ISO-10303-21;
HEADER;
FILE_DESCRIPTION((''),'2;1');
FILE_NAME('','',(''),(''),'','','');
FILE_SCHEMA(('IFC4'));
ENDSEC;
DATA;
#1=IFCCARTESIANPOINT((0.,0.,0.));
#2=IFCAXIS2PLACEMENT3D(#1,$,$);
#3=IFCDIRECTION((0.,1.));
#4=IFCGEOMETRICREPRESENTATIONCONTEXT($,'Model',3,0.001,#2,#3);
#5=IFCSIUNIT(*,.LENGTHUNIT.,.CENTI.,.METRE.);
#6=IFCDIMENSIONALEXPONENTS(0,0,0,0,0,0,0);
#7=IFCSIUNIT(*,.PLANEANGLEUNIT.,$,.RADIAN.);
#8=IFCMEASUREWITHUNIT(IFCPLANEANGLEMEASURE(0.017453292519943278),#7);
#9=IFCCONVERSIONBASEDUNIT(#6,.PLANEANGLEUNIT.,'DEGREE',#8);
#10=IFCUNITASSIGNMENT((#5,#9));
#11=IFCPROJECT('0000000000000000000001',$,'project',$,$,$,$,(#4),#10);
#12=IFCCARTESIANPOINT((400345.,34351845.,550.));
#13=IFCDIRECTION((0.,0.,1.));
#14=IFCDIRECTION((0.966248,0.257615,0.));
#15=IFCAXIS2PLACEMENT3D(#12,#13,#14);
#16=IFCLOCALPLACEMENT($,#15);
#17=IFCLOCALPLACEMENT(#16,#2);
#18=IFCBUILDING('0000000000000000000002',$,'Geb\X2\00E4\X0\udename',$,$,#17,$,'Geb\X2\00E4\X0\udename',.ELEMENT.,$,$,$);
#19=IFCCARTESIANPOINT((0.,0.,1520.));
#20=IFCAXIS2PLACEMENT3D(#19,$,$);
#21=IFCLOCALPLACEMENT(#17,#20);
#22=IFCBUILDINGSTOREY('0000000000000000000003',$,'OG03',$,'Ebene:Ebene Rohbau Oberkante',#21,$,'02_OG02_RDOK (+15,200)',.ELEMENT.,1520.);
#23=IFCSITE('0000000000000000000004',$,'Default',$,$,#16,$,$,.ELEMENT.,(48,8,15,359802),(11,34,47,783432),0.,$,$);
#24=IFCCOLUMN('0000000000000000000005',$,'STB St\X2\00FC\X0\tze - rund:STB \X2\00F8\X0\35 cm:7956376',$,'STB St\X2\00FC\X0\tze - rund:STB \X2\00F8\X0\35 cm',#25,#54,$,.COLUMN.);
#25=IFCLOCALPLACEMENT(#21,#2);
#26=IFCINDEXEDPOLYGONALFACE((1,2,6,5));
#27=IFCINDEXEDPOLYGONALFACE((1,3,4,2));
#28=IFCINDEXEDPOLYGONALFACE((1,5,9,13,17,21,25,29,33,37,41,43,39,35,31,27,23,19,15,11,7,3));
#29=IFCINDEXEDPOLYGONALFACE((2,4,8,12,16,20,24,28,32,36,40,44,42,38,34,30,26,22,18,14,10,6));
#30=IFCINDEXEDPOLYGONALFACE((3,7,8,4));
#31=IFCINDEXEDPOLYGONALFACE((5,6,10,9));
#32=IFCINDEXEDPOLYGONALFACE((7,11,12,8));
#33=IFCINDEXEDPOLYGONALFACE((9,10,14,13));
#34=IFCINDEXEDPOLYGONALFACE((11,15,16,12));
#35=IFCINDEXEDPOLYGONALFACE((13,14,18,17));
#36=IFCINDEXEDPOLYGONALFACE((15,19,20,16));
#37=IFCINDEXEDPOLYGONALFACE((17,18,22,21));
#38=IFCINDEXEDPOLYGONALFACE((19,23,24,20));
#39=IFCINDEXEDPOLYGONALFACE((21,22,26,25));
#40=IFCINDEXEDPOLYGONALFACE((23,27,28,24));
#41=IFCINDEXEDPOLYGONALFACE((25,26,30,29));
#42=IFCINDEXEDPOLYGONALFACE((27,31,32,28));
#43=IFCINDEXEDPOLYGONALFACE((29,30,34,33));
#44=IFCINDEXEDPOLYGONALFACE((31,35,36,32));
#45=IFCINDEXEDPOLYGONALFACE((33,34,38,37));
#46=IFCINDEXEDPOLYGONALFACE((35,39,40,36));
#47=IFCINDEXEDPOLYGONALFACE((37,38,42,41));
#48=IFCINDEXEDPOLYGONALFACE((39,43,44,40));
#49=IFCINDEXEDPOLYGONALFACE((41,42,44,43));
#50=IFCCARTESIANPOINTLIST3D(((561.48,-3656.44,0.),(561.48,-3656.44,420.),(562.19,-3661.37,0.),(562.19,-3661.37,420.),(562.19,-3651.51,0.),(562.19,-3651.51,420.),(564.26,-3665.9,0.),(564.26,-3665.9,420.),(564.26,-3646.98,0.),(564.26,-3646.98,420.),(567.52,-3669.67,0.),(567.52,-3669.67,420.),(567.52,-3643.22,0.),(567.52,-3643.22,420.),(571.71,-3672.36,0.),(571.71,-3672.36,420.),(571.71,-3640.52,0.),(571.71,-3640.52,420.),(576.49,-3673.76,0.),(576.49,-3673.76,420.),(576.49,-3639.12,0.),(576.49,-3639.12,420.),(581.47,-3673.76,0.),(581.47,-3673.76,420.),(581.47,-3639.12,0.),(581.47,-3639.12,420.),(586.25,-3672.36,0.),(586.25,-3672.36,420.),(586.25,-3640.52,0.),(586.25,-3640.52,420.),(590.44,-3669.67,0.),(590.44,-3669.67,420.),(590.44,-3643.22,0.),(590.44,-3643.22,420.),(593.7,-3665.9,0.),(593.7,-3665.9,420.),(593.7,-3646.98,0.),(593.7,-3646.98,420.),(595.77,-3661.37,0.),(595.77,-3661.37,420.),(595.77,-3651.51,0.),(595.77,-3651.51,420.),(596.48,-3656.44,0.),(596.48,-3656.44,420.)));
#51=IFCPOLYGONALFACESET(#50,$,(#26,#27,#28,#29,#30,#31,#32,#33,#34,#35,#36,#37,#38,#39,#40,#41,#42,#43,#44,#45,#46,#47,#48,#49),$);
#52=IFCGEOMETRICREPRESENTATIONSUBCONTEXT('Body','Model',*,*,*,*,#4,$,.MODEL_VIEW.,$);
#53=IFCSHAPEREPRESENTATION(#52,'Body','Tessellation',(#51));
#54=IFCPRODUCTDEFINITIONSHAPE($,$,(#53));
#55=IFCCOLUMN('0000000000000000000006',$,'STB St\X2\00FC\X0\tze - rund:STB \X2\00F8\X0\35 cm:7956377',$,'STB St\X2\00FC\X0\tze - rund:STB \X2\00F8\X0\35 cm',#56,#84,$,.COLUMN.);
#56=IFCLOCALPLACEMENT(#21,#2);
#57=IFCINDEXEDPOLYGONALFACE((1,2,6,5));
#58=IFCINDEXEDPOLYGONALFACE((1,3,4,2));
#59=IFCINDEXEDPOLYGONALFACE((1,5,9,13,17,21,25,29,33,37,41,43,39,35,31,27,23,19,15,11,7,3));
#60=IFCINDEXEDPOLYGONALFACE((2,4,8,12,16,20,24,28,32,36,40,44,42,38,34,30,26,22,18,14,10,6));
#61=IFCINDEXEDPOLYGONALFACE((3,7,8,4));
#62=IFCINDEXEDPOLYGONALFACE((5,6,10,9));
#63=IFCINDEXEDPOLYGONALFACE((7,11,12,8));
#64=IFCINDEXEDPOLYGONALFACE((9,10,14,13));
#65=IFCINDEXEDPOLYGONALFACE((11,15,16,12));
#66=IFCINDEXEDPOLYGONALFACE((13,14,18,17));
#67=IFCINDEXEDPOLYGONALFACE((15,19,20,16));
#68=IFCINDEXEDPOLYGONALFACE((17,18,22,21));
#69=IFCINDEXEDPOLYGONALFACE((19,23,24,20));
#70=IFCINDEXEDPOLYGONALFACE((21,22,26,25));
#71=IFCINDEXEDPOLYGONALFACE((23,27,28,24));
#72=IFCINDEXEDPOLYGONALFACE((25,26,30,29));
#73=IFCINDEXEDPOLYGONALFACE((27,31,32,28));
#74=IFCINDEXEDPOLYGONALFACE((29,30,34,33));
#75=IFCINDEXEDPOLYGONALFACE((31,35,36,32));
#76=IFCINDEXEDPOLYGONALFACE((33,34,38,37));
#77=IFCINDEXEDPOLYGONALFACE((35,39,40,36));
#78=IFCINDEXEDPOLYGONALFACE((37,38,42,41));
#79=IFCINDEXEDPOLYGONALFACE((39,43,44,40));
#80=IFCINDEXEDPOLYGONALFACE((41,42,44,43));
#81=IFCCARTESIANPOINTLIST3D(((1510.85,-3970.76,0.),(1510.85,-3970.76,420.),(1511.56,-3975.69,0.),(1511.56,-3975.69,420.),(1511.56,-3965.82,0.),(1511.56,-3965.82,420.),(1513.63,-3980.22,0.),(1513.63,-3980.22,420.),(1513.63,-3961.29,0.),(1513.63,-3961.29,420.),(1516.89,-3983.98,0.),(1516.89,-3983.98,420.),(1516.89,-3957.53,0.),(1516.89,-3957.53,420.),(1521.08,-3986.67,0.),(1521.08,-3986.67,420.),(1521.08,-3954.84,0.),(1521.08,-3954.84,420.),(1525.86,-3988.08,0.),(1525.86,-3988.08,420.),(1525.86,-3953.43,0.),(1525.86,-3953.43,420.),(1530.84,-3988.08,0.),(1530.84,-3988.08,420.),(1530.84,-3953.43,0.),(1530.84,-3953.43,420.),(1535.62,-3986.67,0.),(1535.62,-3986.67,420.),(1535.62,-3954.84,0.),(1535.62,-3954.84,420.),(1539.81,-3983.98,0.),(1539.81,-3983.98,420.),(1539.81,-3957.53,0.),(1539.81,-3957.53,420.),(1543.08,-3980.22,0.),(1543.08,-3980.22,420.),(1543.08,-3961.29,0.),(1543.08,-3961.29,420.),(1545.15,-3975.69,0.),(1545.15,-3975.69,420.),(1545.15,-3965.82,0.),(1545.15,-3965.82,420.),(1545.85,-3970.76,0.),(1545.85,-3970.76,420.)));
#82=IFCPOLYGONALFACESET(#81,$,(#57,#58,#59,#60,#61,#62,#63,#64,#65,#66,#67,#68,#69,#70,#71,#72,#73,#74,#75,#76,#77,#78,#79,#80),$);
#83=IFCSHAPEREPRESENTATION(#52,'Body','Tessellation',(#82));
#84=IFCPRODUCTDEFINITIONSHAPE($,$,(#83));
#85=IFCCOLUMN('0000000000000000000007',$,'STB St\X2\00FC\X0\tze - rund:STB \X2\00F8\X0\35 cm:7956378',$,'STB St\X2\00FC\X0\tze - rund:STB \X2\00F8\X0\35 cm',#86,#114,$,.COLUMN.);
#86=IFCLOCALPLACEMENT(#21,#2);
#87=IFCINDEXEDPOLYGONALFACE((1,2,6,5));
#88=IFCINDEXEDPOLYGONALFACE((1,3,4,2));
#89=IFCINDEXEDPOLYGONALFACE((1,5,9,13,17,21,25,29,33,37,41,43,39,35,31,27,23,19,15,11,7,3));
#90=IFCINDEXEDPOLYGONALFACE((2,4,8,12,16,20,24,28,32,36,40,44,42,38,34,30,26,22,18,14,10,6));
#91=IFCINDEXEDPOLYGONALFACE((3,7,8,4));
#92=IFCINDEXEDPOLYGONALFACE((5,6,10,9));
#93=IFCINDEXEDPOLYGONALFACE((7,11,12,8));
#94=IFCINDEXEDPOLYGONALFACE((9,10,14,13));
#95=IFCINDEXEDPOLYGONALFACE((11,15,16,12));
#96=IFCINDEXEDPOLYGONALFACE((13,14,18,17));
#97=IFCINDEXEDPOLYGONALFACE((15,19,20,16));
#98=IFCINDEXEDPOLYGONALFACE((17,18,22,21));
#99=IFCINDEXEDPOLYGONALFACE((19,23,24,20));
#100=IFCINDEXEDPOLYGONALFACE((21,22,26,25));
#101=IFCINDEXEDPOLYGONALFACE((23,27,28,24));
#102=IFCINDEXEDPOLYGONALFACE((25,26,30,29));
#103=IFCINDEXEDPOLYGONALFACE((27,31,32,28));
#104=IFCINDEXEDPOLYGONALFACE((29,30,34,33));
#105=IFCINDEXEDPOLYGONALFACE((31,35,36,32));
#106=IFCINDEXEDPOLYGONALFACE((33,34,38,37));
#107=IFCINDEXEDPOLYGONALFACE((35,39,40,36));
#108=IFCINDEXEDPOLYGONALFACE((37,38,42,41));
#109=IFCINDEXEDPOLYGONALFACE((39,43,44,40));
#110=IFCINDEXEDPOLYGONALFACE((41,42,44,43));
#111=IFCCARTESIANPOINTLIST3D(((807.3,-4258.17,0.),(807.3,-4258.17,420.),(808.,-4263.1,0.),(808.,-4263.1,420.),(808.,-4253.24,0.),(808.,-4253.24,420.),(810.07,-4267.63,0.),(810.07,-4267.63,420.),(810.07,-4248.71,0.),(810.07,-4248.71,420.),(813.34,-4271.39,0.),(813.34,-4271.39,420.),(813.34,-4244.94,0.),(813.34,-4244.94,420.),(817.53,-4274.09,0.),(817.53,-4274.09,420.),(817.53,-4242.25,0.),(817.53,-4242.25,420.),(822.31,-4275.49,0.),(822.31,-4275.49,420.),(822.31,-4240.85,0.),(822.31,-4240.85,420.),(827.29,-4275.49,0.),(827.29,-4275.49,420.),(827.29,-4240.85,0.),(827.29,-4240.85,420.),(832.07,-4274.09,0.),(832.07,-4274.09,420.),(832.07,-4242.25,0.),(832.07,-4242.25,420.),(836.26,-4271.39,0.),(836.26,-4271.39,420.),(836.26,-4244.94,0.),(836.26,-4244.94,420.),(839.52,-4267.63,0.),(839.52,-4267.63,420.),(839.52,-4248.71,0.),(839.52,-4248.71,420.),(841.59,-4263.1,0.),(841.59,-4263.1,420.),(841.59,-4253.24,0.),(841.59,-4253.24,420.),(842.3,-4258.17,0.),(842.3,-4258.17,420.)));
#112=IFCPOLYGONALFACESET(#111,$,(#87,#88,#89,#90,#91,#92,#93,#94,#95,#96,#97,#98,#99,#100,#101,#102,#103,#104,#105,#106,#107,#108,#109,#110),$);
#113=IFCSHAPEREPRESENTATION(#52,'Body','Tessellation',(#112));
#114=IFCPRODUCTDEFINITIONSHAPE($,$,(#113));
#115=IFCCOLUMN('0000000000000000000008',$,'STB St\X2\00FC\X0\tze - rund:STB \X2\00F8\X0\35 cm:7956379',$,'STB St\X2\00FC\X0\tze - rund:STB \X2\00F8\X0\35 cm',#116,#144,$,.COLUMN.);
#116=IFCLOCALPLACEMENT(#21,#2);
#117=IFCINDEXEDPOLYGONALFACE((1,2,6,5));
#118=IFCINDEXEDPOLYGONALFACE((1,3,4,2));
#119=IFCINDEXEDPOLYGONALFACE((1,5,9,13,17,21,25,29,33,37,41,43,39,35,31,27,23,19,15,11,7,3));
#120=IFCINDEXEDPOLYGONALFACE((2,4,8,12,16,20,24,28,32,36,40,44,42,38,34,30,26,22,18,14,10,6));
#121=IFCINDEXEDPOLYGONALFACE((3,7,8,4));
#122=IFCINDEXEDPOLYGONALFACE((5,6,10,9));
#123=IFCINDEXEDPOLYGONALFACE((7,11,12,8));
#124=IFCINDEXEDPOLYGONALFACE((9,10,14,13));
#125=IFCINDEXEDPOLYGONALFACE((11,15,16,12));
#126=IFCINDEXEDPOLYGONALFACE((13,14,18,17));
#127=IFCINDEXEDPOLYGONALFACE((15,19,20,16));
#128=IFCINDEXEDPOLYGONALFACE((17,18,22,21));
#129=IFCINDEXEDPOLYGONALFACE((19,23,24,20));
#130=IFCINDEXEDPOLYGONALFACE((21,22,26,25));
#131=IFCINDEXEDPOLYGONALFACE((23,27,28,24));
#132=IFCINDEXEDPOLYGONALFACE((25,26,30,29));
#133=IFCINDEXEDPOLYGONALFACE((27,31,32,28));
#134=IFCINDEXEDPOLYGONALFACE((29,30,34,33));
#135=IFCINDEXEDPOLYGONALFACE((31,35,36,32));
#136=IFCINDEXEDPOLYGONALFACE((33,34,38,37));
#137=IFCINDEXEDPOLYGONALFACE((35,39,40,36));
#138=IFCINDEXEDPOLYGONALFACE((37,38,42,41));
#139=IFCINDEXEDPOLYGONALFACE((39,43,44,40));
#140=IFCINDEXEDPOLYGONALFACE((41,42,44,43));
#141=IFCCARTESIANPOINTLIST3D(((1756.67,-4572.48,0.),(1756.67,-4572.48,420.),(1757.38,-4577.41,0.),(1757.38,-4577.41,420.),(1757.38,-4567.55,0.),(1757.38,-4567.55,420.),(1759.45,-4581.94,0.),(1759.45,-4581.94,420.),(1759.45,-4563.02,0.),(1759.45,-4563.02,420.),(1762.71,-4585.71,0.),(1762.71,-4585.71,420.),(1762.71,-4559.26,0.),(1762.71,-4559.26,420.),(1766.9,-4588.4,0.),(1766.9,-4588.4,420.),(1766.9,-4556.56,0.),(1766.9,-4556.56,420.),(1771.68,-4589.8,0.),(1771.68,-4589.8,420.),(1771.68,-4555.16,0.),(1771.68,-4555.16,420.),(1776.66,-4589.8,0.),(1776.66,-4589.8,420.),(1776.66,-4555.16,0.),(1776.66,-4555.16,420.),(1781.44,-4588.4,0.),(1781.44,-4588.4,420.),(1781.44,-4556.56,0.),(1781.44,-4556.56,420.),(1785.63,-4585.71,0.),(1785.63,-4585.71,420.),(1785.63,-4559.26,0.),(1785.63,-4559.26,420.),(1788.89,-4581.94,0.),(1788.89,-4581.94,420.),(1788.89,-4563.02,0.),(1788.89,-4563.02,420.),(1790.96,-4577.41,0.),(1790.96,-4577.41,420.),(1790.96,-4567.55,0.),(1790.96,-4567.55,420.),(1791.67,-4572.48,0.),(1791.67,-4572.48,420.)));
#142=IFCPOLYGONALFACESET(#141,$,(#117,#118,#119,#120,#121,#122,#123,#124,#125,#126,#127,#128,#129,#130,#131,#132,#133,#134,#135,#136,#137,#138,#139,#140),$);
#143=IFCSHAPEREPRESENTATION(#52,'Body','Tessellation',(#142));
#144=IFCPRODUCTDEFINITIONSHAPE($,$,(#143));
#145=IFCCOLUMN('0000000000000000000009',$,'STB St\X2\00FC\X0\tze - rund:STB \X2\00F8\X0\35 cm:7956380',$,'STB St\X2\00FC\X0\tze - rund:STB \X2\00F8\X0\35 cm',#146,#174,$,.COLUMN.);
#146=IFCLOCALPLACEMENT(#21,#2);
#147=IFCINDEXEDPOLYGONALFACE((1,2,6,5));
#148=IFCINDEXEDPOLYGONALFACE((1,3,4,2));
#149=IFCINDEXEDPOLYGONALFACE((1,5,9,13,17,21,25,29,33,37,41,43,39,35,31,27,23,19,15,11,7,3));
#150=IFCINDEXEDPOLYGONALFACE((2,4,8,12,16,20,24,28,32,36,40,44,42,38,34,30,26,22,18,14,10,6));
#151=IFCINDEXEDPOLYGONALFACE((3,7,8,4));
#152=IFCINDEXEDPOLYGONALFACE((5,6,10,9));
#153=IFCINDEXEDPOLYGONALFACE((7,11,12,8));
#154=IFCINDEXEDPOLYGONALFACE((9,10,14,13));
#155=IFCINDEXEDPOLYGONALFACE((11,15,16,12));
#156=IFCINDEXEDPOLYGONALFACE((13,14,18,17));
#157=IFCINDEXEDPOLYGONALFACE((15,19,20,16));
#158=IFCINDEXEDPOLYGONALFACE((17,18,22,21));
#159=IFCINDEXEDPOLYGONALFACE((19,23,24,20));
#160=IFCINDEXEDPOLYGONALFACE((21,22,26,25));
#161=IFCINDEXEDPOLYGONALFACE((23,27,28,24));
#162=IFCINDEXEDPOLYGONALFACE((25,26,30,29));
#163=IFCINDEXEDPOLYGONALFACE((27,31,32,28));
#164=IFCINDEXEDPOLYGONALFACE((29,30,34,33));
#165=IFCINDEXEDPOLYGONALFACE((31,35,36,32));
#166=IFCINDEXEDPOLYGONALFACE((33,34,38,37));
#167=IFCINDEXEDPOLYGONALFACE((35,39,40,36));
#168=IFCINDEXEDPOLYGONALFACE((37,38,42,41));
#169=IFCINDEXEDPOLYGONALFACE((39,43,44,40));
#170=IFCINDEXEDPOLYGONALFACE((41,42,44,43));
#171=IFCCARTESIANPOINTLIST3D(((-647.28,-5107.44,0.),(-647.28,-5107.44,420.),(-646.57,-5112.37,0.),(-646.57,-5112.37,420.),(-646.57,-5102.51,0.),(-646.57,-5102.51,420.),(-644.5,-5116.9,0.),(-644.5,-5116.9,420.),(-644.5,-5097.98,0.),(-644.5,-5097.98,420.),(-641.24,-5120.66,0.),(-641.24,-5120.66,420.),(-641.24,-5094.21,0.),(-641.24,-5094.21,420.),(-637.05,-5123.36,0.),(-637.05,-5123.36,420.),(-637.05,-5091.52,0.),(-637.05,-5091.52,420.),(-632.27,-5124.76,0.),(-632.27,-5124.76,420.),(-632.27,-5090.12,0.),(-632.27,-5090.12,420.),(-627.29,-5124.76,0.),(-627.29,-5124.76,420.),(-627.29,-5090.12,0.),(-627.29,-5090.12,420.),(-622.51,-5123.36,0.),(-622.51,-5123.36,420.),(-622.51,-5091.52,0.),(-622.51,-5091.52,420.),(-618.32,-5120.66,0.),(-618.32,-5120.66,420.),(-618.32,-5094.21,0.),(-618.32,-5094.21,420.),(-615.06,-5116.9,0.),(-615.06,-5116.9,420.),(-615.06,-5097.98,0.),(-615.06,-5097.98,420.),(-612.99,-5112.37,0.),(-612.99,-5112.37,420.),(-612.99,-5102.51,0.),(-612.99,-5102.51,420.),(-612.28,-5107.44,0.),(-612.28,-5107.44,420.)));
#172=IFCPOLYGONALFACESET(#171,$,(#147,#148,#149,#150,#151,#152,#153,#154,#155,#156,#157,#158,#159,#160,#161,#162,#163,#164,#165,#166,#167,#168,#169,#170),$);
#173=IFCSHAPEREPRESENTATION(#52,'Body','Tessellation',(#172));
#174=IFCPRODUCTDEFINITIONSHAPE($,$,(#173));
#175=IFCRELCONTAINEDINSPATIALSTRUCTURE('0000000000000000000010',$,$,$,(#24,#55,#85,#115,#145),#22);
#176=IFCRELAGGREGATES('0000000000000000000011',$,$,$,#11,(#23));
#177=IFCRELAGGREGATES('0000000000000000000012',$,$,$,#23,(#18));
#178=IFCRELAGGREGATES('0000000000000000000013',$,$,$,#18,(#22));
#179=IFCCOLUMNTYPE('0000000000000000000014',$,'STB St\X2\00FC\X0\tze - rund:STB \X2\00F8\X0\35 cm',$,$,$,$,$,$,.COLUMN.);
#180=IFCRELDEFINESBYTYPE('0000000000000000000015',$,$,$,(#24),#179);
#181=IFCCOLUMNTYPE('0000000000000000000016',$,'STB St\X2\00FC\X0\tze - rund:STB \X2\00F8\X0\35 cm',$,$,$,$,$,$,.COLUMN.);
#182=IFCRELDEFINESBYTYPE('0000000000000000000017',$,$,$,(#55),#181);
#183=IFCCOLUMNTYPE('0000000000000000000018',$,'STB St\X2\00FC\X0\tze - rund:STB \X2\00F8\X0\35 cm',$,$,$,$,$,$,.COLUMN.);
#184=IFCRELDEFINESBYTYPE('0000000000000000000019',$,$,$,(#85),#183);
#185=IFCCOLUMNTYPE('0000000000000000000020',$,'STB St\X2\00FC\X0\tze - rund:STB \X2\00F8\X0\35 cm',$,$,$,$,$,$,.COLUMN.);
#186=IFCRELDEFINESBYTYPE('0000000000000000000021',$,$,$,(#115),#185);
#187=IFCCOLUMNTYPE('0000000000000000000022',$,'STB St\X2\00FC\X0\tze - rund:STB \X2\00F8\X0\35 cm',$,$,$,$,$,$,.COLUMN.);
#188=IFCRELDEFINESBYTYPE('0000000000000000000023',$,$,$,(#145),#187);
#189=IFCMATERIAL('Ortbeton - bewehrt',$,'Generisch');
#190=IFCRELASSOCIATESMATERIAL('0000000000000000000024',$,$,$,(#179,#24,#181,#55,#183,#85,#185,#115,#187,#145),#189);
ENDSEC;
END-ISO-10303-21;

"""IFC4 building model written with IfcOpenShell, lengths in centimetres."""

from ifc_helpers import new_model, entity, si_unit, converted_unit, direction, frame, origin, place, context, subcontext, project, spatial, arc, indexed_curve, outline, extrude, source, transform, mapped, material, type_object, type_shapes, element, save


model = new_model("IFC4")

# Units and contexts
model_context = context("Model", 3, precision=0.001, world=origin(), true_north=direction((0.0, 1.0)))
body_context = subcontext(model_context, "Body", "Model", "MODEL_VIEW")
ifc_project = project(units=[si_unit("LENGTHUNIT", "METRE", prefix="CENTI"), converted_unit("PLANEANGLEUNIT", "DEGREE", entity("IfcPlaneAngleMeasure", 0.017453292519943278), si_unit("PLANEANGLEUNIT", "RADIAN"), dimensions=[0, 0, 0, 0, 0, 0, 0])], contexts=[model_context])

# Site, building, storey
site_placement = place(None, frame((400345.0, 34351845.0, 550.0), z_axis=(0.0, 0.0, 1.0), x_axis=(0.966248, 0.257615, 0.0)))
site = spatial("IfcSite", under=ifc_project, at=site_placement, Name="Default", CompositionType="ELEMENT", RefLatitude=(48, 8, 15, 359802), RefLongitude=(11, 34, 47, 783432), RefElevation=0.0)
building_placement = place(site_placement, origin())
building = spatial("IfcBuilding", under=site, at=building_placement, Name="Gebäudename", LongName="Gebäudename", CompositionType="ELEMENT")
storey_placement = place(building_placement, frame((0.0, 0.0, 1520.0)))
storey = spatial("IfcBuildingStorey", under=building, at=storey_placement, Name="OG03", ObjectType="Ebene:Ebene Rohbau Oberkante", LongName="02_OG02_RDOK (+15,200)", CompositionType="ELEMENT", Elevation=1520.0)

# Columns
ifc_material = material(Name="Ortbeton - bewehrt", Category="Generisch")
column_type_1 = type_object("IfcColumnType", Name="STB Stütze - rund:STB ø35 cm", PredefinedType="COLUMN", material=ifc_material)
shared_shape_1 = source(origin(), body_context, "Body", "SweptSolid", [
    extrude(outline(indexed_curve([(-17.5, 0.0), (0.0, -17.5), (17.5, 0.0), (0.0, 17.5)], segments=[arc(1, 2, 3), arc(3, 4, 1)], self_intersect=False)), frame((578.98, -3656.44, 1520.0)), (0.0, 0.0, 1.0), 420.0),
])
type_shapes(column_type_1, [shared_shape_1])
column_1_placement = place(storey_placement, frame((0.0, 0.0, -1520.0)))
element("IfcColumn", 1, at=column_1_placement, inside=storey, type_object=column_type_1, material=ifc_material, Name="STB Stütze - rund:STB ø35 cm:7956376", ObjectType="STB Stütze - rund:STB ø35 cm", PredefinedType="COLUMN", context=body_context, shape_type="MappedRepresentation", body=[
    mapped(shared_shape_1, transform((0.0, 0.0, 0.0), scale=1.0)),
])
column_type_2 = type_object("IfcColumnType", Name="STB Stütze - rund:STB ø35 cm", PredefinedType="COLUMN", material=ifc_material)
shared_shape_2 = source(origin(), body_context, "Body", "SweptSolid", [
    extrude(outline(indexed_curve([(-17.5, 0.0), (0.0, -17.5), (17.5, 0.0), (0.0, 17.5)], segments=[arc(1, 2, 3), arc(3, 4, 1)], self_intersect=False)), frame((1528.35, -3970.76, 1520.0)), (0.0, 0.0, 1.0), 420.0),
])
type_shapes(column_type_2, [shared_shape_2])
column_2_placement = place(storey_placement, frame((0.0, 0.0, -1520.0)))
element("IfcColumn", 2, at=column_2_placement, inside=storey, type_object=column_type_2, material=ifc_material, Name="STB Stütze - rund:STB ø35 cm:7956377", ObjectType="STB Stütze - rund:STB ø35 cm", PredefinedType="COLUMN", context=body_context, shape_type="MappedRepresentation", body=[
    mapped(shared_shape_2, transform((0.0, 0.0, 0.0), scale=1.0)),
])
column_type_3 = type_object("IfcColumnType", Name="STB Stütze - rund:STB ø35 cm", PredefinedType="COLUMN", material=ifc_material)
shared_shape_3 = source(origin(), body_context, "Body", "SweptSolid", [
    extrude(outline(indexed_curve([(-17.5, 0.0), (0.0, -17.5), (17.5, 0.0), (0.0, 17.5)], segments=[arc(1, 2, 3), arc(3, 4, 1)], self_intersect=False)), frame((824.8, -4258.17, 1520.0)), (0.0, 0.0, 1.0), 420.0),
])
type_shapes(column_type_3, [shared_shape_3])
column_3_placement = place(storey_placement, frame((0.0, 0.0, -1520.0)))
element("IfcColumn", 3, at=column_3_placement, inside=storey, type_object=column_type_3, material=ifc_material, Name="STB Stütze - rund:STB ø35 cm:7956378", ObjectType="STB Stütze - rund:STB ø35 cm", PredefinedType="COLUMN", context=body_context, shape_type="MappedRepresentation", body=[
    mapped(shared_shape_3, transform((0.0, 0.0, 0.0), scale=1.0)),
])
column_type_4 = type_object("IfcColumnType", Name="STB Stütze - rund:STB ø35 cm", PredefinedType="COLUMN", material=ifc_material)
shared_shape_4 = source(origin(), body_context, "Body", "SweptSolid", [
    extrude(outline(indexed_curve([(-17.5, 0.0), (0.0, -17.5), (17.5, 0.0), (0.0, 17.5)], segments=[arc(1, 2, 3), arc(3, 4, 1)], self_intersect=False)), frame((1774.17, -4572.48, 1520.0)), (0.0, 0.0, 1.0), 420.0),
])
type_shapes(column_type_4, [shared_shape_4])
column_4_placement = place(storey_placement, frame((0.0, 0.0, -1520.0)))
element("IfcColumn", 4, at=column_4_placement, inside=storey, type_object=column_type_4, material=ifc_material, Name="STB Stütze - rund:STB ø35 cm:7956379", ObjectType="STB Stütze - rund:STB ø35 cm", PredefinedType="COLUMN", context=body_context, shape_type="MappedRepresentation", body=[
    mapped(shared_shape_4, transform((0.0, 0.0, 0.0), scale=1.0)),
])
column_type_5 = type_object("IfcColumnType", Name="STB Stütze - rund:STB ø35 cm", PredefinedType="COLUMN", material=ifc_material)
shared_shape_5 = source(origin(), body_context, "Body", "SweptSolid", [
    extrude(outline(indexed_curve([(-17.5, 0.0), (0.0, -17.5), (17.5, 0.0), (0.0, 17.5)], segments=[arc(1, 2, 3), arc(3, 4, 1)], self_intersect=False)), frame((-629.78, -5107.44, 1520.0)), (0.0, 0.0, 1.0), 420.0),
])
type_shapes(column_type_5, [shared_shape_5])
column_5_placement = place(storey_placement, frame((0.0, 0.0, -1520.0)))
element("IfcColumn", 5, at=column_5_placement, inside=storey, type_object=column_type_5, material=ifc_material, Name="STB Stütze - rund:STB ø35 cm:7956380", ObjectType="STB Stütze - rund:STB ø35 cm", PredefinedType="COLUMN", context=body_context, shape_type="MappedRepresentation", body=[
    mapped(shared_shape_5, transform((0.0, 0.0, 0.0), scale=1.0)),
])

save(model, "model.ifc")
